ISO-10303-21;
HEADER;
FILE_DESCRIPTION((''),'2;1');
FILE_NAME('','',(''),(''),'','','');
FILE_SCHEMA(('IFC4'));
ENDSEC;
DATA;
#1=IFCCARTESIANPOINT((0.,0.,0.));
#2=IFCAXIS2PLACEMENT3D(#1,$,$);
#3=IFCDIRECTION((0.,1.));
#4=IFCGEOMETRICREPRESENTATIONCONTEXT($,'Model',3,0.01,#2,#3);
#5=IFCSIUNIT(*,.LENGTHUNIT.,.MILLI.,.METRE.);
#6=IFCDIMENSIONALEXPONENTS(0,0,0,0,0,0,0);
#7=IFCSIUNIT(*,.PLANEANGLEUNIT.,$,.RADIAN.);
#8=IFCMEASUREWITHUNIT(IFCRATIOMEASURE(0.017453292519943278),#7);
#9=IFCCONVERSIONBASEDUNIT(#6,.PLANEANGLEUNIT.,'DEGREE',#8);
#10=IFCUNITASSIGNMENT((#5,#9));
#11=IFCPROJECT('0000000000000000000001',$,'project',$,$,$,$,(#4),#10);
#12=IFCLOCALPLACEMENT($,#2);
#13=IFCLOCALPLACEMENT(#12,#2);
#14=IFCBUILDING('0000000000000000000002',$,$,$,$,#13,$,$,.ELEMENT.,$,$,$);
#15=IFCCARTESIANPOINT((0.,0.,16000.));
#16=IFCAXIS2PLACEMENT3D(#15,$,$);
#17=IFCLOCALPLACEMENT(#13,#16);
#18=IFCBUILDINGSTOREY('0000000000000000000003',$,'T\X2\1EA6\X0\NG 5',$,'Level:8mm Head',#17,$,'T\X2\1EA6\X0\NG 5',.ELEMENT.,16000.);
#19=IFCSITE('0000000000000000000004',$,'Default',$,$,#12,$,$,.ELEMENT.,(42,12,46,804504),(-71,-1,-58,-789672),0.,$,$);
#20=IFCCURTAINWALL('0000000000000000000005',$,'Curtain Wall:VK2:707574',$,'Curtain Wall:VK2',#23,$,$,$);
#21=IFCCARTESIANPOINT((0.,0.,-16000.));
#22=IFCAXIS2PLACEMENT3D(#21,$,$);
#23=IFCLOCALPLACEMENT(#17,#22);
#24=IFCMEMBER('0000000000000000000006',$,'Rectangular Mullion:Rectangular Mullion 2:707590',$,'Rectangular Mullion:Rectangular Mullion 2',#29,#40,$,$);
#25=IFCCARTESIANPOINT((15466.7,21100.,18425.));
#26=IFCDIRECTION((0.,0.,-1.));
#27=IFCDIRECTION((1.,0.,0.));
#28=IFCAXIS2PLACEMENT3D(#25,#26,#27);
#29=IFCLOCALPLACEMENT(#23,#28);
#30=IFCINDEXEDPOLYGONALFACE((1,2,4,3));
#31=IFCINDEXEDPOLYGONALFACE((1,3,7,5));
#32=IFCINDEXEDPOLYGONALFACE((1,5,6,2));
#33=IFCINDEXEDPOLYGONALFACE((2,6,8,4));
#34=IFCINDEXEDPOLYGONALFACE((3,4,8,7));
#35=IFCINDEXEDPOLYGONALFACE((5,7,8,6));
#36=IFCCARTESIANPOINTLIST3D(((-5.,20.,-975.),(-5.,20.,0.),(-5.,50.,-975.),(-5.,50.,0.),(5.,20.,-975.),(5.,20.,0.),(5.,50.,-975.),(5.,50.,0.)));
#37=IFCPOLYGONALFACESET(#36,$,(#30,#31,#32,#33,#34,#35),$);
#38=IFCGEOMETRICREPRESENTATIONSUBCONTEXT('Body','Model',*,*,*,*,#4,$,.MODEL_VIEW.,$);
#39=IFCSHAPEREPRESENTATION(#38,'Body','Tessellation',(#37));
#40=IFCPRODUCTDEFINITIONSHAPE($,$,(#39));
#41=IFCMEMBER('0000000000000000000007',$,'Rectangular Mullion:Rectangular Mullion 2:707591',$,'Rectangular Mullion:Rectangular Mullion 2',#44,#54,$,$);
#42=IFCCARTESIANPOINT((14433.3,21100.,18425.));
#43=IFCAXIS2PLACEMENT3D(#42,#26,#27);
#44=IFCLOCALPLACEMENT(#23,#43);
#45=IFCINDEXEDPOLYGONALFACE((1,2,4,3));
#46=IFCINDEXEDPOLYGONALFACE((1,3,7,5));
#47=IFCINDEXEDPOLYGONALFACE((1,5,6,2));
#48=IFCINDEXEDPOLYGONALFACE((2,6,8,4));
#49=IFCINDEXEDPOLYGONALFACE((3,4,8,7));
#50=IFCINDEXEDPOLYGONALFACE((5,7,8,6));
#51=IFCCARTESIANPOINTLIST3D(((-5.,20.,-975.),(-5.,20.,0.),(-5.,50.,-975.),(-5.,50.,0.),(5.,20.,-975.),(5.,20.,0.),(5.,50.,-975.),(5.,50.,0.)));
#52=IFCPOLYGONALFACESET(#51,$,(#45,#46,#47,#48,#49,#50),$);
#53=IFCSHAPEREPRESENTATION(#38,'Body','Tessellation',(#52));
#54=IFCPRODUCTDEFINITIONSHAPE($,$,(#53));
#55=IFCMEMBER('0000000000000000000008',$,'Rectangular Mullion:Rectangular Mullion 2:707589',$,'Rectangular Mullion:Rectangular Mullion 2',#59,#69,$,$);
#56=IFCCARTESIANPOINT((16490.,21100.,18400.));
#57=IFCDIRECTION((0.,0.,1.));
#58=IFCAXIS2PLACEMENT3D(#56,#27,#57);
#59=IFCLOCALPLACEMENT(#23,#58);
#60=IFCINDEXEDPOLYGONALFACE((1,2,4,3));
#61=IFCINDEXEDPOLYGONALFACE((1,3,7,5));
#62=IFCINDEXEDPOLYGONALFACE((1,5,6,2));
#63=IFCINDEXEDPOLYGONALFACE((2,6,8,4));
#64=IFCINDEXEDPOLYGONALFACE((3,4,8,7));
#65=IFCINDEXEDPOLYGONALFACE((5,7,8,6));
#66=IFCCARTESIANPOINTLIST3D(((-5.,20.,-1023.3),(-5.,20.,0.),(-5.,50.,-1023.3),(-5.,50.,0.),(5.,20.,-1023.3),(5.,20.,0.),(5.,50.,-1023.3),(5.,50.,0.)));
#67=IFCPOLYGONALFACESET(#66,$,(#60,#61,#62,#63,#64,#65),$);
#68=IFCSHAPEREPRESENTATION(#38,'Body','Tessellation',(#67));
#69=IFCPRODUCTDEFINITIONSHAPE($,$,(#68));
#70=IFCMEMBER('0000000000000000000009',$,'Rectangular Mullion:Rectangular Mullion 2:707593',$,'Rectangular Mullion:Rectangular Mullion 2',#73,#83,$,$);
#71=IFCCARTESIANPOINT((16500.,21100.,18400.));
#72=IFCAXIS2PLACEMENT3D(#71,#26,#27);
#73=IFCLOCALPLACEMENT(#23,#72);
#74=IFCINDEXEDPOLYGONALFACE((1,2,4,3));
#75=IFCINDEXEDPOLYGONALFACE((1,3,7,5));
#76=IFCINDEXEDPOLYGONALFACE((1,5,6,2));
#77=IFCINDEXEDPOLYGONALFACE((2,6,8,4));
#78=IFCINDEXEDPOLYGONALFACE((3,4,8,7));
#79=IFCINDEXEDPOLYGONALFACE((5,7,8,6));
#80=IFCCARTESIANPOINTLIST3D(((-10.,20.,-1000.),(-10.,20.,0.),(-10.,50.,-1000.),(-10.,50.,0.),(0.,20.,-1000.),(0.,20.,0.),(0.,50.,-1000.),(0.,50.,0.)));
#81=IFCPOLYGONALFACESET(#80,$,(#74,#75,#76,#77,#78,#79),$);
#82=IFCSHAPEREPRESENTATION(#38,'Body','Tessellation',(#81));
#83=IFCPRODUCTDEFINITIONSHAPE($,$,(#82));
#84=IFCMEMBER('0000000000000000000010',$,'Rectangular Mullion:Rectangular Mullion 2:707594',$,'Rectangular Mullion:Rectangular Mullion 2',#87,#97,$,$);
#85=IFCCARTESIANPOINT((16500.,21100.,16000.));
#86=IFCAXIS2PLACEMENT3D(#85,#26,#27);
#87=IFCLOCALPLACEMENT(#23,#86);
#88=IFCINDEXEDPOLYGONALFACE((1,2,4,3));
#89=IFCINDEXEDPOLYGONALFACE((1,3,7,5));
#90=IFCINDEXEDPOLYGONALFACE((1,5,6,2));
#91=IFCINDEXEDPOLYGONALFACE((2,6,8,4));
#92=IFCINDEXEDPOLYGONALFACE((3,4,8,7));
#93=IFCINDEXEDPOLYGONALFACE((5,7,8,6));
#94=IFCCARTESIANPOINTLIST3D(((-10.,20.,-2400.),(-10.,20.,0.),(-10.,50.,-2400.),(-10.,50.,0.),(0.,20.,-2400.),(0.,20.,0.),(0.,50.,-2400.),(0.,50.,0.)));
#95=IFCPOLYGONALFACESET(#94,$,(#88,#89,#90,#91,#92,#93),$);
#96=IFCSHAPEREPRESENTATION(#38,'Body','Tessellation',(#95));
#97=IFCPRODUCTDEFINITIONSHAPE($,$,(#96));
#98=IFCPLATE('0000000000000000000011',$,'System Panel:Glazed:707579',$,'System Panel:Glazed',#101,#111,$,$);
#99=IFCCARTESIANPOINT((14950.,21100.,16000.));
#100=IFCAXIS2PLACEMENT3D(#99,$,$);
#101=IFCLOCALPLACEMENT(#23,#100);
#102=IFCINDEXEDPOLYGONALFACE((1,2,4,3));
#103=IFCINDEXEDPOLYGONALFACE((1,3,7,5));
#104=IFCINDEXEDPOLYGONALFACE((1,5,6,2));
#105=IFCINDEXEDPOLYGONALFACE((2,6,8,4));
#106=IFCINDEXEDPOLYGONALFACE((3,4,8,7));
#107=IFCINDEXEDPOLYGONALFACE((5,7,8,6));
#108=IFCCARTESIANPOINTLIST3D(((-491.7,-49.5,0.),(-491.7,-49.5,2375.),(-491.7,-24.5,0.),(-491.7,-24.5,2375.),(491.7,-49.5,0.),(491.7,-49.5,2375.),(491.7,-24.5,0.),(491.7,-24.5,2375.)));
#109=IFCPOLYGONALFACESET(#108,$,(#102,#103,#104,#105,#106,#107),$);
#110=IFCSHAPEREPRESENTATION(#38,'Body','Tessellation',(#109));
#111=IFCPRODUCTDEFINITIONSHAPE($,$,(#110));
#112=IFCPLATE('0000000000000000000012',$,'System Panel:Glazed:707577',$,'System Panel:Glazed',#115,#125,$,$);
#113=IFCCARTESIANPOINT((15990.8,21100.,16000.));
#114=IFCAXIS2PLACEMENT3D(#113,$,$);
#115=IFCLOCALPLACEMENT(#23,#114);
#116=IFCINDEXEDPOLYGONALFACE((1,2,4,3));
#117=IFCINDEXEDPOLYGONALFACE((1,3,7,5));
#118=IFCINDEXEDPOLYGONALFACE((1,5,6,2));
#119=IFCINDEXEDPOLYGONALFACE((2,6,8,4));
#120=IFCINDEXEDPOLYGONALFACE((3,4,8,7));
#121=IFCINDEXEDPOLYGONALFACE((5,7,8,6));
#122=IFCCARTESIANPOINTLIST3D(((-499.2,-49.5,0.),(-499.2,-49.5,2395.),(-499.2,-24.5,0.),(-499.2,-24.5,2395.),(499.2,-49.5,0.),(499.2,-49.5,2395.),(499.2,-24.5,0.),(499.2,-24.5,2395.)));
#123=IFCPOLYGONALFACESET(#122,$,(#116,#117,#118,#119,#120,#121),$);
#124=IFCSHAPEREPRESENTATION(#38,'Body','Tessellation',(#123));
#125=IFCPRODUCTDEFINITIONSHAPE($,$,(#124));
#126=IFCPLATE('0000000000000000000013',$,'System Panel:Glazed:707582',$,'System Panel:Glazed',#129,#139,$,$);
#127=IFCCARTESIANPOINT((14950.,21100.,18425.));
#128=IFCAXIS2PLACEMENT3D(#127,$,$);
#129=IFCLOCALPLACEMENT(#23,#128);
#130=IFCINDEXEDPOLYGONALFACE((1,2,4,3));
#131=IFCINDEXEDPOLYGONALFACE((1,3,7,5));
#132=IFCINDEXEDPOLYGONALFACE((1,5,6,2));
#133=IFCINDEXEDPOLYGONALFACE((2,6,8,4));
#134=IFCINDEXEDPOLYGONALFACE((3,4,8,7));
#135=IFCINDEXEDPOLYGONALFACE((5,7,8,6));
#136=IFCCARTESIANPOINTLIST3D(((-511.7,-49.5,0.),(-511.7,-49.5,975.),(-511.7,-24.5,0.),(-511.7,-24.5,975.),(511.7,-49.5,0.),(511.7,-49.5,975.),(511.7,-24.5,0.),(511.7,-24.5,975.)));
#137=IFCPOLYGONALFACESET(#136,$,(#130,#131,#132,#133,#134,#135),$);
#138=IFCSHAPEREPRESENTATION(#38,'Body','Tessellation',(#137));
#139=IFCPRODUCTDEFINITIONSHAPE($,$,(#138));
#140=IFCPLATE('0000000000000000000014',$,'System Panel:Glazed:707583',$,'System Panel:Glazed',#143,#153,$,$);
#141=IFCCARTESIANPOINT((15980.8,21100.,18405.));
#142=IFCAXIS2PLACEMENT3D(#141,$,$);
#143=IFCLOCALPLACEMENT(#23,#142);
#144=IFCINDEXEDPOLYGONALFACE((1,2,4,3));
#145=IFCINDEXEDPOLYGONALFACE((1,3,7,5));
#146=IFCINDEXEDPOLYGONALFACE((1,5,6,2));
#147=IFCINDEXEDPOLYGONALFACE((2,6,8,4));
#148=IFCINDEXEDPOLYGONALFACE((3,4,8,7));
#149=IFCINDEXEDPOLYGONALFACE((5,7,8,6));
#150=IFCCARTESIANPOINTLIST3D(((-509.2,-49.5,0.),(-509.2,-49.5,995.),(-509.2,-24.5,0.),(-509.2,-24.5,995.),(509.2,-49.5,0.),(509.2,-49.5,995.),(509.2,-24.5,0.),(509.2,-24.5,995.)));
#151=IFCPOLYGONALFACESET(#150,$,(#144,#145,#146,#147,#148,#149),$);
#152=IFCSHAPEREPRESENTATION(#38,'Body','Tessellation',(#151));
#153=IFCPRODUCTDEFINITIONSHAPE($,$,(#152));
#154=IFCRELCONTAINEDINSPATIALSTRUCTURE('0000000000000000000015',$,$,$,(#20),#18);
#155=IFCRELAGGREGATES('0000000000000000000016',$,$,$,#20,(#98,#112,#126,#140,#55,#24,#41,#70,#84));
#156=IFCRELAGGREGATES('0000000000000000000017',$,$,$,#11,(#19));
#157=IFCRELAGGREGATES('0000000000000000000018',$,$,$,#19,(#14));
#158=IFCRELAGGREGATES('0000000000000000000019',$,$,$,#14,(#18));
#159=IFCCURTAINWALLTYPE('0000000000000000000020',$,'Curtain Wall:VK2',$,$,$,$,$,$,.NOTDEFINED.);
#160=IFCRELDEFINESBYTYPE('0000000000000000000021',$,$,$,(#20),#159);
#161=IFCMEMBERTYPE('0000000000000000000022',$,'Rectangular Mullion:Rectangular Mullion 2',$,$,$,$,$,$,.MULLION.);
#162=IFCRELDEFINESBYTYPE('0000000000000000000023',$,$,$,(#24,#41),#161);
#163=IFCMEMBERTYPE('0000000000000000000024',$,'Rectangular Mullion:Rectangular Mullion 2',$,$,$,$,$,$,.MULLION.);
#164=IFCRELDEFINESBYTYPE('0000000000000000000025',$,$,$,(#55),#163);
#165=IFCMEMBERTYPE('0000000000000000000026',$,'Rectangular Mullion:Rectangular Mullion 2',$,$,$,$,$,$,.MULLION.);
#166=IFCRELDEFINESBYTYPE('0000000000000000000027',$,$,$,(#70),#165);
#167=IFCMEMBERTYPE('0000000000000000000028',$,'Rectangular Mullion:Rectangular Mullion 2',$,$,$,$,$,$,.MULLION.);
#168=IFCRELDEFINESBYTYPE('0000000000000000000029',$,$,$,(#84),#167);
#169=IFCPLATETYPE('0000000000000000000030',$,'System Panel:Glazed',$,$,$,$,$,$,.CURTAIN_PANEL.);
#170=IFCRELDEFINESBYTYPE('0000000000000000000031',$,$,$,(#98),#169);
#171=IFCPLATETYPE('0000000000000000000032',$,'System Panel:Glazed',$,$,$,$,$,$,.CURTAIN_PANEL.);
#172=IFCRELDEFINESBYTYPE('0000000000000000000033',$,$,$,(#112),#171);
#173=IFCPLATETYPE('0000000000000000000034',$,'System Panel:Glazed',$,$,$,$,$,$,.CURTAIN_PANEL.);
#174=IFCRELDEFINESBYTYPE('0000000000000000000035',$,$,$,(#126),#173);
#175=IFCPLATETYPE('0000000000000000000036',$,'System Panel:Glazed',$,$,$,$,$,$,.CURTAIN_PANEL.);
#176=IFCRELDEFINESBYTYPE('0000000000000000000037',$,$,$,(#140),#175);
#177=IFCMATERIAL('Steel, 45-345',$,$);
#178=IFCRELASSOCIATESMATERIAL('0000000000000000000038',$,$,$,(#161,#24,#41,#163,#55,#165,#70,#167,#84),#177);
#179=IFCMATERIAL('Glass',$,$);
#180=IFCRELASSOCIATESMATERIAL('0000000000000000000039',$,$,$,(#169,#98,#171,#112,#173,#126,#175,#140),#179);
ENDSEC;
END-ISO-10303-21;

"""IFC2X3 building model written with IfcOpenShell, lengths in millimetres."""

from ifc_helpers import new_model, entity, si_unit, converted_unit, direction, frame, frame_2d, origin, origin_2d_with_axis, place, context, subcontext, project, spatial, rectangle, extrude, source, transform, mapped, material, type_object, type_shapes, element, aggregate, save


model = new_model("IFC2X3")

# Units and contexts
model_context = context("Model", 3, precision=0.01, world=origin(), true_north=direction((0.0, 1.0)))
body_context = subcontext(model_context, "Body", "Model", "MODEL_VIEW")
ifc_project = project(units=[si_unit("LENGTHUNIT", "METRE", prefix="MILLI"), converted_unit("PLANEANGLEUNIT", "DEGREE", entity("IfcRatioMeasure", 0.017453292519943278), si_unit("PLANEANGLEUNIT", "RADIAN"), dimensions=[0, 0, 0, 0, 0, 0, 0])], contexts=[model_context])

# Site, building, storey
site_placement = place(None, origin())
site = spatial("IfcSite", under=ifc_project, at=site_placement, Name="Default", CompositionType="ELEMENT", RefLatitude=(42, 12, 46, 804504), RefLongitude=(-71, -1, -58, -789672), RefElevation=0.0)
building_placement = place(site_placement, origin())
building = spatial("IfcBuilding", under=site, at=building_placement, CompositionType="ELEMENT")
storey_placement = place(building_placement, frame((0.0, 0.0, 16000.0)))
storey = spatial("IfcBuildingStorey", under=building, at=storey_placement, Name="TẦNG 5", ObjectType="Level:8mm Head", LongName="TẦNG 5", CompositionType="ELEMENT", Elevation=16000.0)

# Curtain wall, members, plates
curtain_wall_type = type_object("IfcCurtainWallType", Name="Curtain Wall:VK2", PredefinedType="NOTDEFINED")
curtain_wall_placement = place(storey_placement, frame((0.0, 0.0, -16000.0)))
curtain_wall = element("IfcCurtainWall", 1, at=curtain_wall_placement, inside=storey, type_object=curtain_wall_type, Name="Curtain Wall:VK2:707574", ObjectType="Curtain Wall:VK2")
ifc_material_1 = material(Name="Steel, 45-345")
member_type_1 = type_object("IfcMemberType", Name="Rectangular Mullion:Rectangular Mullion 2", PredefinedType="MULLION", material=ifc_material_1)
shared_shape_1 = source(origin(), body_context, "Body", "SweptSolid", [
    extrude(rectangle(XDim=30.0, YDim=10.0, at=origin_2d_with_axis()), frame((0.0, 35.0, -975.0), z_axis=(0.0, 0.0, 1.0), x_axis=(0.0, -1.0, 0.0)), (0.0, 0.0, 1.0), 975.0),
])
type_shapes(member_type_1, [shared_shape_1])
member_1_placement = place(curtain_wall_placement, frame((15466.7, 21100.0, 18425.0), z_axis=(0.0, 0.0, -1.0), x_axis=(1.0, 0.0, 0.0)))
member_1 = element("IfcMember", 2, at=member_1_placement, type_object=member_type_1, material=ifc_material_1, Name="Rectangular Mullion:Rectangular Mullion 2:707590", ObjectType="Rectangular Mullion:Rectangular Mullion 2", context=body_context, shape_type="MappedRepresentation", body=[
    mapped(shared_shape_1, transform((0.0, 0.0, 0.0), scale=1.0)),
])
member_2_placement = place(curtain_wall_placement, frame((14433.3, 21100.0, 18425.0), z_axis=(0.0, 0.0, -1.0), x_axis=(1.0, 0.0, 0.0)))
member_2 = element("IfcMember", 3, at=member_2_placement, type_object=member_type_1, material=ifc_material_1, Name="Rectangular Mullion:Rectangular Mullion 2:707591", ObjectType="Rectangular Mullion:Rectangular Mullion 2", context=body_context, shape_type="MappedRepresentation", body=[
    mapped(shared_shape_1, transform((0.0, 0.0, 0.0), scale=1.0)),
])
member_type_2 = type_object("IfcMemberType", Name="Rectangular Mullion:Rectangular Mullion 2", PredefinedType="MULLION", material=ifc_material_1)
shared_shape_2 = source(origin(), body_context, "Body", "SweptSolid", [
    extrude(rectangle(XDim=30.0, YDim=10.0, at=origin_2d_with_axis()), frame((0.0, 35.0, -1023.3), z_axis=(0.0, 0.0, 1.0), x_axis=(0.0, -1.0, 0.0)), (0.0, 0.0, 1.0), 1023.3),
])
type_shapes(member_type_2, [shared_shape_2])
member_3_placement = place(curtain_wall_placement, frame((16490.0, 21100.0, 18400.0), z_axis=(1.0, 0.0, 0.0), x_axis=(0.0, 0.0, 1.0)))
member_3 = element("IfcMember", 4, at=member_3_placement, type_object=member_type_2, material=ifc_material_1, Name="Rectangular Mullion:Rectangular Mullion 2:707589", ObjectType="Rectangular Mullion:Rectangular Mullion 2", context=body_context, shape_type="MappedRepresentation", body=[
    mapped(shared_shape_2, transform((0.0, 0.0, 0.0), scale=1.0)),
])
member_type_3 = type_object("IfcMemberType", Name="Rectangular Mullion:Rectangular Mullion 2", PredefinedType="MULLION", material=ifc_material_1)
shared_shape_3 = source(origin(), body_context, "Body", "SweptSolid", [
    extrude(rectangle(XDim=30.0, YDim=10.0, at=origin_2d_with_axis()), frame((-5.0, 35.0, -1000.0), z_axis=(0.0, 0.0, 1.0), x_axis=(0.0, -1.0, 0.0)), (0.0, 0.0, 1.0), 1000.0),
])
type_shapes(member_type_3, [shared_shape_3])
member_4_placement = place(curtain_wall_placement, frame((16500.0, 21100.0, 18400.0), z_axis=(0.0, 0.0, -1.0), x_axis=(1.0, 0.0, 0.0)))
member_4 = element("IfcMember", 5, at=member_4_placement, type_object=member_type_3, material=ifc_material_1, Name="Rectangular Mullion:Rectangular Mullion 2:707593", ObjectType="Rectangular Mullion:Rectangular Mullion 2", context=body_context, shape_type="MappedRepresentation", body=[
    mapped(shared_shape_3, transform((0.0, 0.0, 0.0), scale=1.0)),
])
member_type_4 = type_object("IfcMemberType", Name="Rectangular Mullion:Rectangular Mullion 2", PredefinedType="MULLION", material=ifc_material_1)
shared_shape_4 = source(origin(), body_context, "Body", "SweptSolid", [
    extrude(rectangle(XDim=30.0, YDim=10.0, at=origin_2d_with_axis()), frame((-5.0, 35.0, -2400.0), z_axis=(0.0, 0.0, 1.0), x_axis=(0.0, -1.0, 0.0)), (0.0, 0.0, 1.0), 2400.0),
])
type_shapes(member_type_4, [shared_shape_4])
member_5_placement = place(curtain_wall_placement, frame((16500.0, 21100.0, 16000.0), z_axis=(0.0, 0.0, -1.0), x_axis=(1.0, 0.0, 0.0)))
member_5 = element("IfcMember", 6, at=member_5_placement, type_object=member_type_4, material=ifc_material_1, Name="Rectangular Mullion:Rectangular Mullion 2:707594", ObjectType="Rectangular Mullion:Rectangular Mullion 2", context=body_context, shape_type="MappedRepresentation", body=[
    mapped(shared_shape_4, transform((0.0, 0.0, 0.0), scale=1.0)),
])
ifc_material_2 = material(Name="Glass")
plate_type_1 = type_object("IfcPlateType", Name="System Panel:Glazed", PredefinedType="CURTAIN_PANEL", material=ifc_material_2)
shared_shape_5 = source(origin(), body_context, "Body", "SweptSolid", [
    extrude(rectangle(XDim=25.0, YDim=983.3, at=frame_2d((0.0, 0.0), x_axis=(1.0, 0.0))), frame((0.0, -37.0, 0.0), z_axis=(0.0, 0.0, 1.0), x_axis=(0.0, 1.0, 0.0)), (0.0, 0.0, 1.0), 2375.0),
])
type_shapes(plate_type_1, [shared_shape_5])
plate_1_placement = place(curtain_wall_placement, frame((14950.0, 21100.0, 16000.0)))
plate_1 = element("IfcPlate", 7, at=plate_1_placement, type_object=plate_type_1, material=ifc_material_2, Name="System Panel:Glazed:707579", ObjectType="System Panel:Glazed", context=body_context, shape_type="MappedRepresentation", body=[
    mapped(shared_shape_5, transform((0.0, 0.0, 0.0), scale=1.0)),
])
plate_type_2 = type_object("IfcPlateType", Name="System Panel:Glazed", PredefinedType="CURTAIN_PANEL", material=ifc_material_2)
shared_shape_6 = source(origin(), body_context, "Body", "SweptSolid", [
    extrude(rectangle(XDim=25.0, YDim=998.3, at=frame_2d((0.0, 0.0), x_axis=(1.0, 0.0))), frame((0.0, -37.0, 0.0), z_axis=(0.0, 0.0, 1.0), x_axis=(0.0, 1.0, 0.0)), (0.0, 0.0, 1.0), 2395.0),
])
type_shapes(plate_type_2, [shared_shape_6])
plate_2_placement = place(curtain_wall_placement, frame((15990.8, 21100.0, 16000.0)))
plate_2 = element("IfcPlate", 8, at=plate_2_placement, type_object=plate_type_2, material=ifc_material_2, Name="System Panel:Glazed:707577", ObjectType="System Panel:Glazed", context=body_context, shape_type="MappedRepresentation", body=[
    mapped(shared_shape_6, transform((0.0, 0.0, 0.0), scale=1.0)),
])
plate_type_3 = type_object("IfcPlateType", Name="System Panel:Glazed", PredefinedType="CURTAIN_PANEL", material=ifc_material_2)
shared_shape_7 = source(origin(), body_context, "Body", "SweptSolid", [
    extrude(rectangle(XDim=25.0, YDim=1023.3, at=frame_2d((0.0, 0.0), x_axis=(1.0, 0.0))), frame((0.0, -37.0, 0.0), z_axis=(0.0, 0.0, 1.0), x_axis=(0.0, 1.0, 0.0)), (0.0, 0.0, 1.0), 975.0),
])
type_shapes(plate_type_3, [shared_shape_7])
plate_3_placement = place(curtain_wall_placement, frame((14950.0, 21100.0, 18425.0)))
plate_3 = element("IfcPlate", 9, at=plate_3_placement, type_object=plate_type_3, material=ifc_material_2, Name="System Panel:Glazed:707582", ObjectType="System Panel:Glazed", context=body_context, shape_type="MappedRepresentation", body=[
    mapped(shared_shape_7, transform((0.0, 0.0, 0.0), scale=1.0)),
])
plate_type_4 = type_object("IfcPlateType", Name="System Panel:Glazed", PredefinedType="CURTAIN_PANEL", material=ifc_material_2)
shared_shape_8 = source(origin(), body_context, "Body", "SweptSolid", [
    extrude(rectangle(XDim=25.0, YDim=1018.3, at=frame_2d((0.0, 0.0), x_axis=(1.0, 0.0))), frame((0.0, -37.0, 0.0), z_axis=(0.0, 0.0, 1.0), x_axis=(0.0, 1.0, 0.0)), (0.0, 0.0, 1.0), 995.0),
])
type_shapes(plate_type_4, [shared_shape_8])
plate_4_placement = place(curtain_wall_placement, frame((15980.8, 21100.0, 18405.0)))
plate_4 = element("IfcPlate", 10, at=plate_4_placement, type_object=plate_type_4, material=ifc_material_2, Name="System Panel:Glazed:707583", ObjectType="System Panel:Glazed", context=body_context, shape_type="MappedRepresentation", body=[
    mapped(shared_shape_8, transform((0.0, 0.0, 0.0), scale=1.0)),
])
aggregate(curtain_wall, [plate_1, plate_2, plate_3, plate_4, member_3, member_1, member_2, member_4, member_5])

save(model, "model.ifc")
